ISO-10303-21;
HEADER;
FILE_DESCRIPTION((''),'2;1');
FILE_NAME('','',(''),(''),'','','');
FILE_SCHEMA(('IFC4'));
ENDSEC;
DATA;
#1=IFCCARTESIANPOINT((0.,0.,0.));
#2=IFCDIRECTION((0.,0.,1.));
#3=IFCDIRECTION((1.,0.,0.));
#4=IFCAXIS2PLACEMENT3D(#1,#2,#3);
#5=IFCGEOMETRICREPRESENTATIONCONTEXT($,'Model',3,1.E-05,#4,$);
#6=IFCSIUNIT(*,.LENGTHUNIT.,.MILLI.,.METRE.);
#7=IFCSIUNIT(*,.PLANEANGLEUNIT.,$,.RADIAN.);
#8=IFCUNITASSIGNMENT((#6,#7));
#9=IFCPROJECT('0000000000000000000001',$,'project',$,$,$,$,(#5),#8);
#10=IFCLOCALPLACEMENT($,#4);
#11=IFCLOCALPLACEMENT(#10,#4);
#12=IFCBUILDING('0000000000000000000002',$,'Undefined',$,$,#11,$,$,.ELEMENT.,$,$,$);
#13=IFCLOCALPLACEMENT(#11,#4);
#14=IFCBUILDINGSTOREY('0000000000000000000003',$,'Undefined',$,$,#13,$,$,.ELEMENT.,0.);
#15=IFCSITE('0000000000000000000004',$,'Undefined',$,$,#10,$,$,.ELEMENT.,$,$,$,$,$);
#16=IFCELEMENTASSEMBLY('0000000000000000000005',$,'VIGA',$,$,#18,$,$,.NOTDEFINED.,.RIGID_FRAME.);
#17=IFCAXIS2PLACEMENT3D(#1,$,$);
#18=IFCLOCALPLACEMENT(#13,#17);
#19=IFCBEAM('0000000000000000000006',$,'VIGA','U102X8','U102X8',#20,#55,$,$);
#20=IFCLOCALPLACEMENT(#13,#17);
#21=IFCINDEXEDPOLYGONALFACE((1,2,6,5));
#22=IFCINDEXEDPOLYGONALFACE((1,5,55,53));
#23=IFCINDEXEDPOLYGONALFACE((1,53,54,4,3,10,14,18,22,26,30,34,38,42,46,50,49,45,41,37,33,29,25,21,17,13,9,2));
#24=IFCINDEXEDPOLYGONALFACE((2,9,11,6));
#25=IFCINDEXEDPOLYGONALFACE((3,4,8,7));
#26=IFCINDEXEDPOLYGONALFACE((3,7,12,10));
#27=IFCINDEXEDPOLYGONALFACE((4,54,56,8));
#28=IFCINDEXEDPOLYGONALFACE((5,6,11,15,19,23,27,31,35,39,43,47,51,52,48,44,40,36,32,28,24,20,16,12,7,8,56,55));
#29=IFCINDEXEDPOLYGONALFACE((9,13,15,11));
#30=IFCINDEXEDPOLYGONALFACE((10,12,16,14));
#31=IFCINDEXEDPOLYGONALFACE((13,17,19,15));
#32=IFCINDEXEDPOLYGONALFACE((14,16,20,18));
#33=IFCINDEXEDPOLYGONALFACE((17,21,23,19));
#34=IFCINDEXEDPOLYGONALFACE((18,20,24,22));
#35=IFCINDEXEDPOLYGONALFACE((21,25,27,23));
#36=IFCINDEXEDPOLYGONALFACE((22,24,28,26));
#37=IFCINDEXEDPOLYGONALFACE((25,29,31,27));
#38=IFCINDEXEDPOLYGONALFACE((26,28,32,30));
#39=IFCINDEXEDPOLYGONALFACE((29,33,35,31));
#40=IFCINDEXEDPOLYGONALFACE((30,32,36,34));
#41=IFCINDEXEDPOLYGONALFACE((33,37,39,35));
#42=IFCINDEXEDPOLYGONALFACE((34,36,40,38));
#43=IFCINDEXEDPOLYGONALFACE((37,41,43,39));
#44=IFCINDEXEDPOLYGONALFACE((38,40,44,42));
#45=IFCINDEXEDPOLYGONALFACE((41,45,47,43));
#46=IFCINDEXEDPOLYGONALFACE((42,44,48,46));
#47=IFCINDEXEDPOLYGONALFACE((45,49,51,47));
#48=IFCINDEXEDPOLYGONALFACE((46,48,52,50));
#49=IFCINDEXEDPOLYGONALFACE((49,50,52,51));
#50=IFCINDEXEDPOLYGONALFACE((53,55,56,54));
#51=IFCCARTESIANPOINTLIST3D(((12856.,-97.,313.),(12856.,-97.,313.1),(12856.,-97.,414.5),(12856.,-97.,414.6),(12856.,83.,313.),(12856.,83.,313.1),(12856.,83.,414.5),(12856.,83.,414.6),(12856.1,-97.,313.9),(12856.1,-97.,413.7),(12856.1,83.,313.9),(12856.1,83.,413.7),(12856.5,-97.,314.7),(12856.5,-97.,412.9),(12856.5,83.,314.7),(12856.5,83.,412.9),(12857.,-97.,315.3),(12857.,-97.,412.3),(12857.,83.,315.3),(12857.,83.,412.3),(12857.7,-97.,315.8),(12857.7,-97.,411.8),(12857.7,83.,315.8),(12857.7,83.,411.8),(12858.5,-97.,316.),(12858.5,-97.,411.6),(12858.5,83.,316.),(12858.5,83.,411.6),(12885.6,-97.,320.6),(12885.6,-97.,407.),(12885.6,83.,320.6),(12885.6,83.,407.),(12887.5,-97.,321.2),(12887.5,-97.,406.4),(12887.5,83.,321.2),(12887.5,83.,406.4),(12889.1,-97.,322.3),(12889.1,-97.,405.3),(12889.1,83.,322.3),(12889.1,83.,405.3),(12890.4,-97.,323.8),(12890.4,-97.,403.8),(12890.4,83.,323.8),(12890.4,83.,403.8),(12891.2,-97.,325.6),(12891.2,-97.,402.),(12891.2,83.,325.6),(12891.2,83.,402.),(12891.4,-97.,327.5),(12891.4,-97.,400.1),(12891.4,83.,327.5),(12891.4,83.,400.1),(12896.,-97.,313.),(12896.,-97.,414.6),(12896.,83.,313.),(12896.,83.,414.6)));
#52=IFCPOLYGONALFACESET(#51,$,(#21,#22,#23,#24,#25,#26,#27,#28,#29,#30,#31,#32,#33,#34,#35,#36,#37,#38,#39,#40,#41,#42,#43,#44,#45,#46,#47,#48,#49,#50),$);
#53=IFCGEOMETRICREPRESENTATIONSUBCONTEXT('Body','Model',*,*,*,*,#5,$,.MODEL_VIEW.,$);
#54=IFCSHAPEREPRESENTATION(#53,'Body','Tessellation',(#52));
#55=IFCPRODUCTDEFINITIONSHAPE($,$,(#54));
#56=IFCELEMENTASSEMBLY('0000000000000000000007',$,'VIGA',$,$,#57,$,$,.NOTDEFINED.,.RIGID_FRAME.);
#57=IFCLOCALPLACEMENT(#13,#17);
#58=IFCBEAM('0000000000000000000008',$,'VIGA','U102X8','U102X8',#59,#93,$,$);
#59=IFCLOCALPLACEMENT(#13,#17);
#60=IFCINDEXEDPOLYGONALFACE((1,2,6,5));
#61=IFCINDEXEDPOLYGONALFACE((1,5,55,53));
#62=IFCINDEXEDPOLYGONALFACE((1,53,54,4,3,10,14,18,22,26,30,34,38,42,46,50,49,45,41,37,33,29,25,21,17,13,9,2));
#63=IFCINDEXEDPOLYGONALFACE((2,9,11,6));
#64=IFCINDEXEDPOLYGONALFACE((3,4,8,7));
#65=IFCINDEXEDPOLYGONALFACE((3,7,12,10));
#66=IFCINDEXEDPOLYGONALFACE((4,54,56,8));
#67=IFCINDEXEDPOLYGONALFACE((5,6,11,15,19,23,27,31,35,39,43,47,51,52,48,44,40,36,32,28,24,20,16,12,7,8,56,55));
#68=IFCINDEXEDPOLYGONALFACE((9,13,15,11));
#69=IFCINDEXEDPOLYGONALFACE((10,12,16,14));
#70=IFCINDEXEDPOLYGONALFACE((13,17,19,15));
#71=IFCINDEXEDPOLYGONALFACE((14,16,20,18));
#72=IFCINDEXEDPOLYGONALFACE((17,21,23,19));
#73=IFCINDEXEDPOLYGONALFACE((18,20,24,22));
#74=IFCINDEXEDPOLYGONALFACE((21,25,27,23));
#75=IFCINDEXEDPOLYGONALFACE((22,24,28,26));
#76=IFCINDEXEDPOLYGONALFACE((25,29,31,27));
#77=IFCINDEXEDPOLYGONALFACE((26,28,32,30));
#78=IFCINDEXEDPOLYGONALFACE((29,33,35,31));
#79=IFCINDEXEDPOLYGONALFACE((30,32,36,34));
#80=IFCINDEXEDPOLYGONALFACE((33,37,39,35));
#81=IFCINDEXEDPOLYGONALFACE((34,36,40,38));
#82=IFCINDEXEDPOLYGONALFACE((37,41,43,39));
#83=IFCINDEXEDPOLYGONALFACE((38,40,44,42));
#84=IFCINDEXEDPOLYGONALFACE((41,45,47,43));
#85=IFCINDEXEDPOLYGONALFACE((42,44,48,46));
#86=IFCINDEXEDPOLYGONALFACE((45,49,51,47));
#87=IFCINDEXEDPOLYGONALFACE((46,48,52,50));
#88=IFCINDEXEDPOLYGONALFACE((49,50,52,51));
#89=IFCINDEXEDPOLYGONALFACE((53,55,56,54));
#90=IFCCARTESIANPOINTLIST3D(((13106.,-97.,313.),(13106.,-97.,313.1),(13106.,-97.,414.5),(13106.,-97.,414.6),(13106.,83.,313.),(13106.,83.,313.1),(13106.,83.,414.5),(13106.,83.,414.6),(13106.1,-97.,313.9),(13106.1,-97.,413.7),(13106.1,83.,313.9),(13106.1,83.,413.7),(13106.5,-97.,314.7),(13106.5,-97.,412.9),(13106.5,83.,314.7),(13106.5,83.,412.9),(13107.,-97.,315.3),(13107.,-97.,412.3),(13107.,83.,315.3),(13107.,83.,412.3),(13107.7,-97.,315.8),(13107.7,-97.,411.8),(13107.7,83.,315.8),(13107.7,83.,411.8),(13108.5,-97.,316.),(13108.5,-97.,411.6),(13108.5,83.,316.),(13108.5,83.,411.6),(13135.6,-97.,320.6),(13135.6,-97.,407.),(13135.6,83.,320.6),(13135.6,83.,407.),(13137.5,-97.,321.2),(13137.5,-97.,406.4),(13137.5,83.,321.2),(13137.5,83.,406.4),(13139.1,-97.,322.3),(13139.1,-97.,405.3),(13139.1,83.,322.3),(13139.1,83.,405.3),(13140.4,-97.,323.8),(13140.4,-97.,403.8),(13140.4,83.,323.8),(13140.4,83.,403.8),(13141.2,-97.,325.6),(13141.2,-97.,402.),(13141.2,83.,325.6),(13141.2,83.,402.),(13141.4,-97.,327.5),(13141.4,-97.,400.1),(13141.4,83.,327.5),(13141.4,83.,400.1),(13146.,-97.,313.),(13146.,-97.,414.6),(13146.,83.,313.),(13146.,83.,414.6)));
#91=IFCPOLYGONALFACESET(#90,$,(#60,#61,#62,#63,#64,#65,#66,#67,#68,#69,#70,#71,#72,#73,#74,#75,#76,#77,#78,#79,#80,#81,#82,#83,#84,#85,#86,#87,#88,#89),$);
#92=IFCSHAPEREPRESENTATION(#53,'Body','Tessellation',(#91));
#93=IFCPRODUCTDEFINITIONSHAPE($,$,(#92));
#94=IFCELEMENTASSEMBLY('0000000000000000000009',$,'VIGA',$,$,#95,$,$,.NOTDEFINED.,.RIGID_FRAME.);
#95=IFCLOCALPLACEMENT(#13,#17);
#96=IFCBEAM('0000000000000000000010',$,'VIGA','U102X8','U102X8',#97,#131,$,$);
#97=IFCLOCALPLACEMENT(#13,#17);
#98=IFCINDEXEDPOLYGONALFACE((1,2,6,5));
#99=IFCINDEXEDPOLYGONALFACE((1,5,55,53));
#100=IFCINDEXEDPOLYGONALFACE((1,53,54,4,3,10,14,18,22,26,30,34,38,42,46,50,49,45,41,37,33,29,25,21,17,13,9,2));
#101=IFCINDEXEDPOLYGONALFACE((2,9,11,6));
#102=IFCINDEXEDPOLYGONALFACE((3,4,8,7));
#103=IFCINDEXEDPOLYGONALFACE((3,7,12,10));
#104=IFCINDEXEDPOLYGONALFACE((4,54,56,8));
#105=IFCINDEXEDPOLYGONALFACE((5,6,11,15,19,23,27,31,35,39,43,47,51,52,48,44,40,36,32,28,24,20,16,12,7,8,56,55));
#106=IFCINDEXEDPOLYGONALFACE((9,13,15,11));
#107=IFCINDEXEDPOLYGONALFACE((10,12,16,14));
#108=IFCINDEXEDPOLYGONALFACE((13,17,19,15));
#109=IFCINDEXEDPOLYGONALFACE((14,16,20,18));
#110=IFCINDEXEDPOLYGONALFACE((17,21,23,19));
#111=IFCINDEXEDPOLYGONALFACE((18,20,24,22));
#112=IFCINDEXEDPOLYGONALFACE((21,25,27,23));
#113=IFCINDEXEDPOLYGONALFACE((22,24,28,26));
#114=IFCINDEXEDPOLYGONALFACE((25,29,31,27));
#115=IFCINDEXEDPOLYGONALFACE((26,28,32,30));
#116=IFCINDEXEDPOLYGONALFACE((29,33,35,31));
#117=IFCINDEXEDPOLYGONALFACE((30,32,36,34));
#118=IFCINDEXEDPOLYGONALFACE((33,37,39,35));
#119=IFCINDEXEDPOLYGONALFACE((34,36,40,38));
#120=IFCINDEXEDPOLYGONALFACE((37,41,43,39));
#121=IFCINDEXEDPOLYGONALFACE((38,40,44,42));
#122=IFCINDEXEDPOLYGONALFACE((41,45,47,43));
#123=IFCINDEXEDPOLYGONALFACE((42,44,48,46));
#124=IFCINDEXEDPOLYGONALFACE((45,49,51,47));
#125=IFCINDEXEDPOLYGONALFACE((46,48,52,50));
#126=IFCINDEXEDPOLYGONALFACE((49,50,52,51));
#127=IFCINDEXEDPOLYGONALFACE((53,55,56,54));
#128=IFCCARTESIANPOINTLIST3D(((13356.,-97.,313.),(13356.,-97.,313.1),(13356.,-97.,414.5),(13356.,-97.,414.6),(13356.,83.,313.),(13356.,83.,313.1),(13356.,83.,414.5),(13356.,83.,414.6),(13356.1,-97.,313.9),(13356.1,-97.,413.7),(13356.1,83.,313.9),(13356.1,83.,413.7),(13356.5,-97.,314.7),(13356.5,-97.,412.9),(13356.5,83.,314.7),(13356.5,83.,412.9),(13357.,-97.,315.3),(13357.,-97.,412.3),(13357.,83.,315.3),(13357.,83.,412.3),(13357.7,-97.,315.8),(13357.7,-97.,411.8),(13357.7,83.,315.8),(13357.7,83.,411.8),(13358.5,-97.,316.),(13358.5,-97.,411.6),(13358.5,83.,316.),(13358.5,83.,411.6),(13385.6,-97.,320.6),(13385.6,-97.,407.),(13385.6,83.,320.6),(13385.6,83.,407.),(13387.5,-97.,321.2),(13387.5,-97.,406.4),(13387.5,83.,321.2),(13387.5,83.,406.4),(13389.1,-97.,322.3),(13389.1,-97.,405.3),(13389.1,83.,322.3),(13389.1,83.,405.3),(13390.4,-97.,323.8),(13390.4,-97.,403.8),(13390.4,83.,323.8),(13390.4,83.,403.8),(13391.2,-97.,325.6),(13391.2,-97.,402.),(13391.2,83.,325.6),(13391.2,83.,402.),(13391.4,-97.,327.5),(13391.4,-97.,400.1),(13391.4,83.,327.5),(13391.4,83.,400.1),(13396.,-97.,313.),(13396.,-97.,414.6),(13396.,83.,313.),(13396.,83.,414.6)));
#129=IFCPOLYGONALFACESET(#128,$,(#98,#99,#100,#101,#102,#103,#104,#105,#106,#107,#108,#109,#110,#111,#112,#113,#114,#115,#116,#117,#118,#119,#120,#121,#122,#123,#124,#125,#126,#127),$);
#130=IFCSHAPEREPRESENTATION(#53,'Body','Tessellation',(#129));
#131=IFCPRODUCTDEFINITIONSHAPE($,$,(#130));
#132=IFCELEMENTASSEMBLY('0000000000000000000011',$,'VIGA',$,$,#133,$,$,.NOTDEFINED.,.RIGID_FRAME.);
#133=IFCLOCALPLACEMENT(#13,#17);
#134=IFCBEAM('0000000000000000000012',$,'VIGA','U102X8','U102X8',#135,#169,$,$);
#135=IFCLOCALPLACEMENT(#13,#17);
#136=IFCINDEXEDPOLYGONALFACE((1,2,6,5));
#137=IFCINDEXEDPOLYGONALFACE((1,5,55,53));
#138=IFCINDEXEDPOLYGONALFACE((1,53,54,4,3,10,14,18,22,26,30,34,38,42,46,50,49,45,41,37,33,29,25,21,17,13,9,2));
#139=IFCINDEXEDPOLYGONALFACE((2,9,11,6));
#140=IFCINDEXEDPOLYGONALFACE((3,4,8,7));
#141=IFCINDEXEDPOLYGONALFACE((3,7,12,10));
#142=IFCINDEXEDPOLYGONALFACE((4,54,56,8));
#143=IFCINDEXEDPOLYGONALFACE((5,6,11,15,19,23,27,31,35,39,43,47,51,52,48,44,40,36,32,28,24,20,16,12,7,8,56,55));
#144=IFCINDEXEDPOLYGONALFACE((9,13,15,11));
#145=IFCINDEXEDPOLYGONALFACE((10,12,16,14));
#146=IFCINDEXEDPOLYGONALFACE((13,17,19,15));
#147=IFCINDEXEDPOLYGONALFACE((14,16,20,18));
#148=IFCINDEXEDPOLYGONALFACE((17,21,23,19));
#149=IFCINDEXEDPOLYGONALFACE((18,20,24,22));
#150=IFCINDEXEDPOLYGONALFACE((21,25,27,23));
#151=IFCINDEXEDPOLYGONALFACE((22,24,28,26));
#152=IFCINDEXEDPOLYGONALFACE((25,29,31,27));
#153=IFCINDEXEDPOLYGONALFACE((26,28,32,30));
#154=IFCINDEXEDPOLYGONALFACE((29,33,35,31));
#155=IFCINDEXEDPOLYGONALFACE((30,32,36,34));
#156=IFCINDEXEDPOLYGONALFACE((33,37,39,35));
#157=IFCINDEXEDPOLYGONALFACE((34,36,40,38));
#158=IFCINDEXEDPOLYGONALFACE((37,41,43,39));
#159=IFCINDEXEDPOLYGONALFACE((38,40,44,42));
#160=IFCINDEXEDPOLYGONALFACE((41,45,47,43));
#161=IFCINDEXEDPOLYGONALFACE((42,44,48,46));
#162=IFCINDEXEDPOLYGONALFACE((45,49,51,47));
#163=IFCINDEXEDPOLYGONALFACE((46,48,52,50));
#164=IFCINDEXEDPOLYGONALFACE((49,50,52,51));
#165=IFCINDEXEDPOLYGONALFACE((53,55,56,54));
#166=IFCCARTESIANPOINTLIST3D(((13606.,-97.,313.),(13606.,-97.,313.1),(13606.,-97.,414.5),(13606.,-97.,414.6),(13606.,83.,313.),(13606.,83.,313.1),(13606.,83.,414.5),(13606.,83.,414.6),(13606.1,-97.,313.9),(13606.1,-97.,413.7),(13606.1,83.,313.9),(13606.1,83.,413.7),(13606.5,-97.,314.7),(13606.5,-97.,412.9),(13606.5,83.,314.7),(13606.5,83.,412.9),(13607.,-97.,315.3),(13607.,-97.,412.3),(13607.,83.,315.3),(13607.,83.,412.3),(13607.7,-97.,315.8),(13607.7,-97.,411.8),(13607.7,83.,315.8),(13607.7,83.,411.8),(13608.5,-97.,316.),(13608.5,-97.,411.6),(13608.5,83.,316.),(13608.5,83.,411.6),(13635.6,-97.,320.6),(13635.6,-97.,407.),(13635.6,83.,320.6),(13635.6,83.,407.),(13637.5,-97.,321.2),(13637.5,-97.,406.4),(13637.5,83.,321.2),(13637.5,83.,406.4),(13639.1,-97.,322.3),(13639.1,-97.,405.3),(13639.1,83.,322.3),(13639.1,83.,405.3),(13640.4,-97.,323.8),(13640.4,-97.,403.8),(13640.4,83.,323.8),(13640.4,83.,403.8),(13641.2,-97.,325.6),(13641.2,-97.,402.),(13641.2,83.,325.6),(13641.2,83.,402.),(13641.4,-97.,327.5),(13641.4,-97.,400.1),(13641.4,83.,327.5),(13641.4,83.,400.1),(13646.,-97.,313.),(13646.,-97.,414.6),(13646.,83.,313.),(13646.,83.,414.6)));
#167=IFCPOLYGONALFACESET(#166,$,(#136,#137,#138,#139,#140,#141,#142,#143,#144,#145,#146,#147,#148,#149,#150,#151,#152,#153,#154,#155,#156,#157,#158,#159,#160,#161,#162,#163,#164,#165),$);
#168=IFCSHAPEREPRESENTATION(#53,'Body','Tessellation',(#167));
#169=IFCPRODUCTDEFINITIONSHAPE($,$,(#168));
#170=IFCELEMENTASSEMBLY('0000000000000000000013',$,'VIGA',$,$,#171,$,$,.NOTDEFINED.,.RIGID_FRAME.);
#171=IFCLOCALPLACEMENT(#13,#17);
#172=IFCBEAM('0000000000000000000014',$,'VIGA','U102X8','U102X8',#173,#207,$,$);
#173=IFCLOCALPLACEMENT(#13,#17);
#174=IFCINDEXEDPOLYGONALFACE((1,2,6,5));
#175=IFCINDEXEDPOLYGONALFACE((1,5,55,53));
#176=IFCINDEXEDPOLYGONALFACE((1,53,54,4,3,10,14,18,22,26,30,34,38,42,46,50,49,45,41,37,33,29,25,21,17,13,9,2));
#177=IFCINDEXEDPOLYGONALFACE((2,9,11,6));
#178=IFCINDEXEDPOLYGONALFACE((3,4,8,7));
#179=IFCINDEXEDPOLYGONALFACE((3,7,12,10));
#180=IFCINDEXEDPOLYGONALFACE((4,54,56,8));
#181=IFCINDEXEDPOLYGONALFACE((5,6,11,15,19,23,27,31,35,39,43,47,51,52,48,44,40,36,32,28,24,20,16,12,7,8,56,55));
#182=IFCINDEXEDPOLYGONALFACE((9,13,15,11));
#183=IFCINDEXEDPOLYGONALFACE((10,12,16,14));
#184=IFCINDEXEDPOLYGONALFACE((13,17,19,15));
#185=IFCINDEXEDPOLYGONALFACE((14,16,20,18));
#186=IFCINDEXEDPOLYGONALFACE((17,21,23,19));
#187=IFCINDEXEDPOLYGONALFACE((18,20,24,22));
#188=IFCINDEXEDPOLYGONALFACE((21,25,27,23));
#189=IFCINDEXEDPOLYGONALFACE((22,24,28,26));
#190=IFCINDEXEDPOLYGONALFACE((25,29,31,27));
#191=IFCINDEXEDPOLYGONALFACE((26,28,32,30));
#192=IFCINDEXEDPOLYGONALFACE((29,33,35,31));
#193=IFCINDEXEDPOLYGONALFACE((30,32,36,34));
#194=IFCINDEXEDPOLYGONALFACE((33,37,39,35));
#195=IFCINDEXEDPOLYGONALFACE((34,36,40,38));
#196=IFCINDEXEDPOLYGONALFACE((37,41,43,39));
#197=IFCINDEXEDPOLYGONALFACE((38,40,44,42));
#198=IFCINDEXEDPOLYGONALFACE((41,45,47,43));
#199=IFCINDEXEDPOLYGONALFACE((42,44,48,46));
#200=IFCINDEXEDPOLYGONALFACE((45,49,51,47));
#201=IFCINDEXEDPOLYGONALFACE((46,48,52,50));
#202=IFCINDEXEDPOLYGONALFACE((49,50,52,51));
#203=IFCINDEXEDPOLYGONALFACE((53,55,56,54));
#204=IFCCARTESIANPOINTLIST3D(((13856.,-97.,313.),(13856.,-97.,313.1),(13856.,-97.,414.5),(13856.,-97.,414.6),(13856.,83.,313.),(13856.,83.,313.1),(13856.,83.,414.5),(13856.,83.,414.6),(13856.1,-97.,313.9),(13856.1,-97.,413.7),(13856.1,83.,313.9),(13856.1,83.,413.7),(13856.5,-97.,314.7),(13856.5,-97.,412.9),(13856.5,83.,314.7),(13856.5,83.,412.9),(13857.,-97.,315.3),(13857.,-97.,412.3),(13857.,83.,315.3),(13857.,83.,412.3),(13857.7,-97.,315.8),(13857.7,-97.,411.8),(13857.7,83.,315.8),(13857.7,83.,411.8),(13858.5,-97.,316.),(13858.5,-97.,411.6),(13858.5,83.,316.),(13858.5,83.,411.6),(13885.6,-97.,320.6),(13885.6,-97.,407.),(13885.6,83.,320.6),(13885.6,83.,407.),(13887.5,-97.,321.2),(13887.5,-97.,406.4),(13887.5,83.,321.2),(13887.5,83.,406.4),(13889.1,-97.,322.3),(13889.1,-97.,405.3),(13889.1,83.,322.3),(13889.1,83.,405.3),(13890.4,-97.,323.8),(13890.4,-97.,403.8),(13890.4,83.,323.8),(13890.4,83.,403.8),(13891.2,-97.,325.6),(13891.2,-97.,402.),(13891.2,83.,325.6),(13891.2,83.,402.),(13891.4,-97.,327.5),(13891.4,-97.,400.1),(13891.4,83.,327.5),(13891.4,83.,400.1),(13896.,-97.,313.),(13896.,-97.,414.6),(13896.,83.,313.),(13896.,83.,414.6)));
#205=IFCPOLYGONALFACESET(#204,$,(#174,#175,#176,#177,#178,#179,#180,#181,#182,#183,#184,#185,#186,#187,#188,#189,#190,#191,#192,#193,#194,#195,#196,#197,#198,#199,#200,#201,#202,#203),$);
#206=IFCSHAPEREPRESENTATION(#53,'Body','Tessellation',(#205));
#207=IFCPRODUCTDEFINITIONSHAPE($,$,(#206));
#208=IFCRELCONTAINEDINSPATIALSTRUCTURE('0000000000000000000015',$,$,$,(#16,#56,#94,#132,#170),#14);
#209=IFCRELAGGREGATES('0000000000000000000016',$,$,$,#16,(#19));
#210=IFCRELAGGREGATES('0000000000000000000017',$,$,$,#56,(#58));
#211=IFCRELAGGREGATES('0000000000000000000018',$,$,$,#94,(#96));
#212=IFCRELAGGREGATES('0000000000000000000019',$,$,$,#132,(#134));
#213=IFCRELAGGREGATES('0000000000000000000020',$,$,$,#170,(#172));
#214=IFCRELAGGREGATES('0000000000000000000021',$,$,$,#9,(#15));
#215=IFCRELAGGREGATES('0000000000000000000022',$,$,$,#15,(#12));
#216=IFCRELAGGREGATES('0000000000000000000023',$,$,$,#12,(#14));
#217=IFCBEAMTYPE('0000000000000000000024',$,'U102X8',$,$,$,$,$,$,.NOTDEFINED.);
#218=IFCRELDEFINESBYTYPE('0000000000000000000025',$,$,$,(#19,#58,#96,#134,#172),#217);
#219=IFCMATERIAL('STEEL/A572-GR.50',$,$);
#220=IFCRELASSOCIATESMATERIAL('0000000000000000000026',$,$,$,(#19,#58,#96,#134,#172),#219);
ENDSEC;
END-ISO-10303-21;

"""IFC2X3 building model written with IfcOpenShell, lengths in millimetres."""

from ifc_helpers import new_model, si_unit, frame, origin_with_axes, origin_2d_with_axis, place, context, subcontext, project, spatial, u_section, extrude, material, type_object, element, aggregate, save


model = new_model("IFC2X3")

# Units and contexts
model_context = context("Model", 3, precision=1e-05, world=origin_with_axes())
body_context = subcontext(model_context, "Body", "Model", "MODEL_VIEW")
ifc_project = project(units=[si_unit("LENGTHUNIT", "METRE", prefix="MILLI"), si_unit("PLANEANGLEUNIT", "RADIAN")], contexts=[model_context])

# Site, building, storey
site_placement = place(None, origin_with_axes())
site = spatial("IfcSite", under=ifc_project, at=site_placement, Name="Undefined", CompositionType="ELEMENT")
building_placement = place(site_placement, origin_with_axes())
building = spatial("IfcBuilding", under=site, at=building_placement, Name="Undefined", CompositionType="ELEMENT")
storey_placement = place(building_placement, origin_with_axes())
storey = spatial("IfcBuildingStorey", under=building, at=storey_placement, Name="Undefined", CompositionType="ELEMENT", Elevation=0.0)

# Element assemblies, beams
ifc_material_1 = material(Name="STEEL/A572-GR.50")
beam_type_1 = type_object("IfcBeamType", Name="U102X8", PredefinedType="NOTDEFINED")
assembly_1_placement = place(storey_placement, origin_with_axes())
assembly_1 = element("IfcElementAssembly", 1, at=assembly_1_placement, inside=storey, Name="VIGA", AssemblyPlace="NOTDEFINED", PredefinedType="RIGID_FRAME")
beam_1_placement = place(assembly_1_placement, frame((12876.0, 83.0, 363.8), z_axis=(0.0, 0.0, 1.0), x_axis=(0.0, -1.0, 0.0)))
beam_1 = element("IfcBeam", 2, at=beam_1_placement, type_object=beam_type_1, material=ifc_material_1, Name="VIGA", Description="U102X8", ObjectType="U102X8", context=body_context, shape_type="SweptSolid", body=[
    extrude(u_section(Depth=101.6, FlangeWidth=40.0, WebThickness=4.6, FlangeThickness=6.0, FilletRadius=7.0, EdgeRadius=3.0, FlangeSlope=0.16839, at=origin_2d_with_axis()), frame((180.0, 0.0, 0.0), z_axis=(-1.0, 0.0, 0.0), x_axis=(0.0, -1.0, 0.0)), (0.0, 0.0, 1.0), 180.0),
])
aggregate(assembly_1, [beam_1])
assembly_2_placement = place(storey_placement, origin_with_axes())
assembly_2 = element("IfcElementAssembly", 3, at=assembly_2_placement, inside=storey, Name="VIGA", AssemblyPlace="NOTDEFINED", PredefinedType="RIGID_FRAME")
beam_2_placement = place(assembly_2_placement, frame((13126.0, 83.0, 363.8), z_axis=(0.0, 0.0, 1.0), x_axis=(0.0, -1.0, 0.0)))
beam_2 = element("IfcBeam", 4, at=beam_2_placement, type_object=beam_type_1, material=ifc_material_1, Name="VIGA", Description="U102X8", ObjectType="U102X8", context=body_context, shape_type="SweptSolid", body=[
    extrude(u_section(Depth=101.6, FlangeWidth=40.0, WebThickness=4.6, FlangeThickness=6.0, FilletRadius=7.0, EdgeRadius=3.0, FlangeSlope=0.16839, at=origin_2d_with_axis()), frame((180.0, 0.0, 0.0), z_axis=(-1.0, 0.0, 0.0), x_axis=(0.0, -1.0, 0.0)), (0.0, 0.0, 1.0), 180.0),
])
aggregate(assembly_2, [beam_2])
assembly_3_placement = place(storey_placement, origin_with_axes())
assembly_3 = element("IfcElementAssembly", 5, at=assembly_3_placement, inside=storey, Name="VIGA", AssemblyPlace="NOTDEFINED", PredefinedType="RIGID_FRAME")
beam_3_placement = place(assembly_3_placement, frame((13376.0, 83.0, 363.8), z_axis=(0.0, 0.0, 1.0), x_axis=(0.0, -1.0, 0.0)))
beam_3 = element("IfcBeam", 6, at=beam_3_placement, type_object=beam_type_1, material=ifc_material_1, Name="VIGA", Description="U102X8", ObjectType="U102X8", context=body_context, shape_type="SweptSolid", body=[
    extrude(u_section(Depth=101.6, FlangeWidth=40.0, WebThickness=4.6, FlangeThickness=6.0, FilletRadius=7.0, EdgeRadius=3.0, FlangeSlope=0.16839, at=origin_2d_with_axis()), frame((180.0, 0.0, 0.0), z_axis=(-1.0, 0.0, 0.0), x_axis=(0.0, -1.0, 0.0)), (0.0, 0.0, 1.0), 180.0),
])
aggregate(assembly_3, [beam_3])
assembly_4_placement = place(storey_placement, origin_with_axes())
assembly_4 = element("IfcElementAssembly", 7, at=assembly_4_placement, inside=storey, Name="VIGA", AssemblyPlace="NOTDEFINED", PredefinedType="RIGID_FRAME")
beam_4_placement = place(assembly_4_placement, frame((13626.0, 83.0, 363.8), z_axis=(0.0, 0.0, 1.0), x_axis=(0.0, -1.0, 0.0)))
beam_4 = element("IfcBeam", 8, at=beam_4_placement, type_object=beam_type_1, material=ifc_material_1, Name="VIGA", Description="U102X8", ObjectType="U102X8", context=body_context, shape_type="SweptSolid", body=[
    extrude(u_section(Depth=101.6, FlangeWidth=40.0, WebThickness=4.6, FlangeThickness=6.0, FilletRadius=7.0, EdgeRadius=3.0, FlangeSlope=0.16839, at=origin_2d_with_axis()), frame((180.0, 0.0, 0.0), z_axis=(-1.0, 0.0, 0.0), x_axis=(0.0, -1.0, 0.0)), (0.0, 0.0, 1.0), 180.0),
])
aggregate(assembly_4, [beam_4])
assembly_5_placement = place(storey_placement, origin_with_axes())
assembly_5 = element("IfcElementAssembly", 9, at=assembly_5_placement, inside=storey, Name="VIGA", AssemblyPlace="NOTDEFINED", PredefinedType="RIGID_FRAME")
beam_5_placement = place(assembly_5_placement, frame((13876.0, 83.0, 363.8), z_axis=(0.0, 0.0, 1.0), x_axis=(0.0, -1.0, 0.0)))
beam_5 = element("IfcBeam", 10, at=beam_5_placement, type_object=beam_type_1, material=ifc_material_1, Name="VIGA", Description="U102X8", ObjectType="U102X8", context=body_context, shape_type="SweptSolid", body=[
    extrude(u_section(Depth=101.6, FlangeWidth=40.0, WebThickness=4.6, FlangeThickness=6.0, FilletRadius=7.0, EdgeRadius=3.0, FlangeSlope=0.16839, at=origin_2d_with_axis()), frame((180.0, 0.0, 0.0), z_axis=(-1.0, 0.0, 0.0), x_axis=(0.0, -1.0, 0.0)), (0.0, 0.0, 1.0), 180.0),
])
aggregate(assembly_5, [beam_5])

save(model, "model.ifc")
